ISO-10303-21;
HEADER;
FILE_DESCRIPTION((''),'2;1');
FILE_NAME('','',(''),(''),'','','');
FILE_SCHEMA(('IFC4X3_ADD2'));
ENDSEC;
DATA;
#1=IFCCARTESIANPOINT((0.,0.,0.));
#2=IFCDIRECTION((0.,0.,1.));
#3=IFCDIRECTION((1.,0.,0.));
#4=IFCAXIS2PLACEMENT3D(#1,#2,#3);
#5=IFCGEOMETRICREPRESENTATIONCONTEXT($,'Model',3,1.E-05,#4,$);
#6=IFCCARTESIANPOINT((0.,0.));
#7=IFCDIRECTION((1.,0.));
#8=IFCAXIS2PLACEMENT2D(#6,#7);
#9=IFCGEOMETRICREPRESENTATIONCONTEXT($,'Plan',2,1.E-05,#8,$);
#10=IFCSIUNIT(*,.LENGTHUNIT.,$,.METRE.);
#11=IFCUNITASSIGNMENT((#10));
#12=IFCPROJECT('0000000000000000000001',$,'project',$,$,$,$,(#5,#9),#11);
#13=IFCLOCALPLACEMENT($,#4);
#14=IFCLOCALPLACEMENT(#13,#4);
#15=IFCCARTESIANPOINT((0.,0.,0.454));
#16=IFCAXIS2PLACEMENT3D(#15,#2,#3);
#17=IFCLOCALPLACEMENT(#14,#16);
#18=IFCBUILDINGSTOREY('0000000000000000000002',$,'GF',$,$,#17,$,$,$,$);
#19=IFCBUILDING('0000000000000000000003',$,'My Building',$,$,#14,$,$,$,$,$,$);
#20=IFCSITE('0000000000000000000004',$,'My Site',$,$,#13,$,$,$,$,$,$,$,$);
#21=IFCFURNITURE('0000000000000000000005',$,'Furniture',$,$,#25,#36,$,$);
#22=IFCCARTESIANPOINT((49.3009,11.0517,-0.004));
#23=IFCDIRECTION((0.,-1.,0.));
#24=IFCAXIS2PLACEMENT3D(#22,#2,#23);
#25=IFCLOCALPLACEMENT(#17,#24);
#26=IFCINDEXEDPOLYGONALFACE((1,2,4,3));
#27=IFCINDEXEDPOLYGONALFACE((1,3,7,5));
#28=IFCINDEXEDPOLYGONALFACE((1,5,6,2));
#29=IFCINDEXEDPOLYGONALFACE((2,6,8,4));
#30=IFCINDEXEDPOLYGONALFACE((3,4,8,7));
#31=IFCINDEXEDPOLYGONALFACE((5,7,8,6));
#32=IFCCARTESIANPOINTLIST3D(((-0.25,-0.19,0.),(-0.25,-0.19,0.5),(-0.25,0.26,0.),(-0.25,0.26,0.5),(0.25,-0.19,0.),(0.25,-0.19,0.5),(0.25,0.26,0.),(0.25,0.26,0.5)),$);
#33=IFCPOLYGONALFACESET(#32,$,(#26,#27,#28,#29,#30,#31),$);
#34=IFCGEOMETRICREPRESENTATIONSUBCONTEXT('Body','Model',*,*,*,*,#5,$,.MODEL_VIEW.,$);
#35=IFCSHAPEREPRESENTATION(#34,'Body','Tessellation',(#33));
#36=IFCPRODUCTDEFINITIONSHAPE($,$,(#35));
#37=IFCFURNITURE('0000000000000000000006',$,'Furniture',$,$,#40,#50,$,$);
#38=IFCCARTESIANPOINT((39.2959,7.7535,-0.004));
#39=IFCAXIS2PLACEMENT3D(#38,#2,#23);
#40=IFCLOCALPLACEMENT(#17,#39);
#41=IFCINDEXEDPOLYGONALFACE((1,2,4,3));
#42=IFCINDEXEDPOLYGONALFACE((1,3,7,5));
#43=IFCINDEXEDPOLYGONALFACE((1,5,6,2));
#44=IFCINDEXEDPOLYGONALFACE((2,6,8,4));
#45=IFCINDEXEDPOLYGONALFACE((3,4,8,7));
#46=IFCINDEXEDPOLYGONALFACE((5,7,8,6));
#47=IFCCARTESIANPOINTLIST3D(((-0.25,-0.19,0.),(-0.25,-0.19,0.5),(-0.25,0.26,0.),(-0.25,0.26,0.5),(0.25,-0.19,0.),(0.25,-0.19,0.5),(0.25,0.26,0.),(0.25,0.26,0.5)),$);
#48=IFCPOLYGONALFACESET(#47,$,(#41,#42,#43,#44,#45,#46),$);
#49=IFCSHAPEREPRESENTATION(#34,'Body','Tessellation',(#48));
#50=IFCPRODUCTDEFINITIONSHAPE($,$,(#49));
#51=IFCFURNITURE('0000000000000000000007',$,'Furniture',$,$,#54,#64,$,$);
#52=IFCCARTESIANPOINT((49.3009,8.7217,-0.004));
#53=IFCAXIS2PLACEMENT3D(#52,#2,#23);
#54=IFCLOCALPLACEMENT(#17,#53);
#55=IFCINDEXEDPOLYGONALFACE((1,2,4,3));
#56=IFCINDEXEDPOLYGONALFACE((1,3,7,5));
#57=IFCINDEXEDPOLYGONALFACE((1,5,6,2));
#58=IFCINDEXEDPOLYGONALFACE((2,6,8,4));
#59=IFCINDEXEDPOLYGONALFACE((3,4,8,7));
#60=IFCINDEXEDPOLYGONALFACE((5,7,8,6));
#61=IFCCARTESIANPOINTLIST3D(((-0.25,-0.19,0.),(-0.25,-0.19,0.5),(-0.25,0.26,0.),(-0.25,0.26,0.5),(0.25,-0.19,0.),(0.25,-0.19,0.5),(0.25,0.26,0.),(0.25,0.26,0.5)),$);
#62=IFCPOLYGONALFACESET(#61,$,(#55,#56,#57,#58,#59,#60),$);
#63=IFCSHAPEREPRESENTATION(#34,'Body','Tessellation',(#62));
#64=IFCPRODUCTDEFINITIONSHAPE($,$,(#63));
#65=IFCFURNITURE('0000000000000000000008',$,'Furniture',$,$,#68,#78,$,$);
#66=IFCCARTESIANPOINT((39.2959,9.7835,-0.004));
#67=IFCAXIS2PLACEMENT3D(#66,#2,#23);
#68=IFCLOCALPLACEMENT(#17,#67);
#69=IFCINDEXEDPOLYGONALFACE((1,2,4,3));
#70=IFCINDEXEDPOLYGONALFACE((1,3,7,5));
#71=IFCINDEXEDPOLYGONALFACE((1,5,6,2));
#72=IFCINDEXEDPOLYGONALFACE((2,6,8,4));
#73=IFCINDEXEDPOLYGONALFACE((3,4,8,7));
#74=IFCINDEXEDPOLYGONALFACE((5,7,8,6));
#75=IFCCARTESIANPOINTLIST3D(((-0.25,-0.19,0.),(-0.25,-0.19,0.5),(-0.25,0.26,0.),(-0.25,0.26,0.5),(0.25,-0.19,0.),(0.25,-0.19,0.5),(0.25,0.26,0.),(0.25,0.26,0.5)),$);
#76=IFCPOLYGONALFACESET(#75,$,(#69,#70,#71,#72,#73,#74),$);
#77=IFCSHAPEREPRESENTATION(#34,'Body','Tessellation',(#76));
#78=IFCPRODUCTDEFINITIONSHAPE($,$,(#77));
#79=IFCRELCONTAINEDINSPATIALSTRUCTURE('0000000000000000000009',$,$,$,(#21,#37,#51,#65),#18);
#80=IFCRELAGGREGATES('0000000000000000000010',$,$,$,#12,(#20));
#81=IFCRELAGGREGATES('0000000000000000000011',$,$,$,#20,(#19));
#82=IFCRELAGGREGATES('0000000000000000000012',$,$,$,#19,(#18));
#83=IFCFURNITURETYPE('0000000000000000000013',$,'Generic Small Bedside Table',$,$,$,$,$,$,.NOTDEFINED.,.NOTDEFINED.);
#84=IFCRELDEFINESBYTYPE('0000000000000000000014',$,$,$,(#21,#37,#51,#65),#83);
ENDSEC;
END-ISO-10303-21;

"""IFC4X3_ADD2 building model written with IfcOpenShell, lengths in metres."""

from ifc_helpers import new_model, entity, si_unit, frame, origin_with_axes, origin_2d_with_axis, place, context, subcontext, project, spatial, line, indexed_curve, outline, extrude, shape, source, transform, mapped, type_object, type_shapes, element, save


model = new_model("IFC4X3_ADD2")

# Units and contexts
model_context = context("Model", 3, precision=1e-05, world=origin_with_axes())
plan_context = context("Plan", 2, precision=1e-05, world=origin_2d_with_axis())
body_context_1 = subcontext(model_context, "Body", "Model", "MODEL_VIEW")
body_context_2 = subcontext(plan_context, "Body", "Plan", "PLAN_VIEW")
ifc_project = project(units=[si_unit("LENGTHUNIT", "METRE")], contexts=[model_context, plan_context])

# Site, building, storey
site_placement = place(None, origin_with_axes())
site = spatial("IfcSite", under=ifc_project, at=site_placement, Name="My Site")
building_placement = place(site_placement, origin_with_axes())
building = spatial("IfcBuilding", under=site, at=building_placement, Name="My Building")
storey_placement = place(building_placement, frame((0.0, 0.0, 0.454), z_axis=(0.0, 0.0, 1.0), x_axis=(1.0, 0.0, 0.0)))
storey = spatial("IfcBuildingStorey", under=building, at=storey_placement, Name="GF")

# Furniture
furniture_type_1 = type_object("IfcFurnitureType", Name="Generic Small Bedside Table", AssemblyPlace="NOTDEFINED", PredefinedType="NOTDEFINED")
shared_shape_1 = source(origin_with_axes(), body_context_1, "Body", "SweptSolid", [
    extrude(outline(indexed_curve([(0.5, 0.45), (0.5, 0.0), (0.0, 0.0), (0.0, 0.45)], segments=[line(4, 1), line(1, 2), line(2, 3), line(3, 4)], self_intersect=False)), frame((-0.25, -0.19, 0.0), z_axis=(0.0, 0.0, 1.0), x_axis=(1.0, 0.0, 0.0)), (0.0, 0.0, 1.0), 0.5),
])
shared_shape_2 = source(origin_with_axes(), body_context_2, "Body", "Annotation2D", [
    entity("IfcGeometricCurveSet", [entity("IfcIndexedPolyCurve", entity("IfcCartesianPointList2D", [[-0.25, -0.19], [0.25, -0.19], [0.25, 0.26], [-0.25, 0.26]]), [entity("IfcLineIndex", [1, 2]), entity("IfcLineIndex", [2, 3]), entity("IfcLineIndex", [3, 4]), entity("IfcLineIndex", [4, 1])])]),
])
type_shapes(furniture_type_1, [shared_shape_1, shared_shape_2])
for number, where, z_axis, x_axis, name in (
    (1, (49.3009, 11.0517, -0.004), (0.0, 0.0, 1.0), (0.0, -1.0, 0.0), "Furniture"),
    (2, (39.2959, 7.7535, -0.004), (0.0, 0.0, 1.0), (0.0, -1.0, 0.0), "Furniture"),
    (3, (49.3009, 8.7217, -0.004), (0.0, 0.0, 1.0), (0.0, -1.0, 0.0), "Furniture"),
    (4, (39.2959, 9.7835, -0.004), (0.0, 0.0, 1.0), (0.0, -1.0, 0.0), "Furniture"),
):
    element("IfcFurniture", number, at=place(storey_placement, frame(where, z_axis=z_axis, x_axis=x_axis)), inside=storey, type_object=furniture_type_1, Name=name, shapes=[
        shape(body_context_1, "Body", "MappedRepresentation", [mapped(shared_shape_1, transform((0.0, 0.0, 0.0), x_axis=(1.0, 0.0, 0.0), y_axis=(0.0, 1.0, 0.0), z_axis=(0.0, 0.0, 1.0), scale=1.0))]),
        shape(body_context_2, "Body", "MappedRepresentation", [mapped(shared_shape_2, transform((0.0, 0.0, 0.0), x_axis=(1.0, 0.0, 0.0), y_axis=(0.0, 1.0, 0.0), z_axis=(0.0, 0.0, 1.0), scale=1.0))]),
    ])

save(model, "model.ifc")
